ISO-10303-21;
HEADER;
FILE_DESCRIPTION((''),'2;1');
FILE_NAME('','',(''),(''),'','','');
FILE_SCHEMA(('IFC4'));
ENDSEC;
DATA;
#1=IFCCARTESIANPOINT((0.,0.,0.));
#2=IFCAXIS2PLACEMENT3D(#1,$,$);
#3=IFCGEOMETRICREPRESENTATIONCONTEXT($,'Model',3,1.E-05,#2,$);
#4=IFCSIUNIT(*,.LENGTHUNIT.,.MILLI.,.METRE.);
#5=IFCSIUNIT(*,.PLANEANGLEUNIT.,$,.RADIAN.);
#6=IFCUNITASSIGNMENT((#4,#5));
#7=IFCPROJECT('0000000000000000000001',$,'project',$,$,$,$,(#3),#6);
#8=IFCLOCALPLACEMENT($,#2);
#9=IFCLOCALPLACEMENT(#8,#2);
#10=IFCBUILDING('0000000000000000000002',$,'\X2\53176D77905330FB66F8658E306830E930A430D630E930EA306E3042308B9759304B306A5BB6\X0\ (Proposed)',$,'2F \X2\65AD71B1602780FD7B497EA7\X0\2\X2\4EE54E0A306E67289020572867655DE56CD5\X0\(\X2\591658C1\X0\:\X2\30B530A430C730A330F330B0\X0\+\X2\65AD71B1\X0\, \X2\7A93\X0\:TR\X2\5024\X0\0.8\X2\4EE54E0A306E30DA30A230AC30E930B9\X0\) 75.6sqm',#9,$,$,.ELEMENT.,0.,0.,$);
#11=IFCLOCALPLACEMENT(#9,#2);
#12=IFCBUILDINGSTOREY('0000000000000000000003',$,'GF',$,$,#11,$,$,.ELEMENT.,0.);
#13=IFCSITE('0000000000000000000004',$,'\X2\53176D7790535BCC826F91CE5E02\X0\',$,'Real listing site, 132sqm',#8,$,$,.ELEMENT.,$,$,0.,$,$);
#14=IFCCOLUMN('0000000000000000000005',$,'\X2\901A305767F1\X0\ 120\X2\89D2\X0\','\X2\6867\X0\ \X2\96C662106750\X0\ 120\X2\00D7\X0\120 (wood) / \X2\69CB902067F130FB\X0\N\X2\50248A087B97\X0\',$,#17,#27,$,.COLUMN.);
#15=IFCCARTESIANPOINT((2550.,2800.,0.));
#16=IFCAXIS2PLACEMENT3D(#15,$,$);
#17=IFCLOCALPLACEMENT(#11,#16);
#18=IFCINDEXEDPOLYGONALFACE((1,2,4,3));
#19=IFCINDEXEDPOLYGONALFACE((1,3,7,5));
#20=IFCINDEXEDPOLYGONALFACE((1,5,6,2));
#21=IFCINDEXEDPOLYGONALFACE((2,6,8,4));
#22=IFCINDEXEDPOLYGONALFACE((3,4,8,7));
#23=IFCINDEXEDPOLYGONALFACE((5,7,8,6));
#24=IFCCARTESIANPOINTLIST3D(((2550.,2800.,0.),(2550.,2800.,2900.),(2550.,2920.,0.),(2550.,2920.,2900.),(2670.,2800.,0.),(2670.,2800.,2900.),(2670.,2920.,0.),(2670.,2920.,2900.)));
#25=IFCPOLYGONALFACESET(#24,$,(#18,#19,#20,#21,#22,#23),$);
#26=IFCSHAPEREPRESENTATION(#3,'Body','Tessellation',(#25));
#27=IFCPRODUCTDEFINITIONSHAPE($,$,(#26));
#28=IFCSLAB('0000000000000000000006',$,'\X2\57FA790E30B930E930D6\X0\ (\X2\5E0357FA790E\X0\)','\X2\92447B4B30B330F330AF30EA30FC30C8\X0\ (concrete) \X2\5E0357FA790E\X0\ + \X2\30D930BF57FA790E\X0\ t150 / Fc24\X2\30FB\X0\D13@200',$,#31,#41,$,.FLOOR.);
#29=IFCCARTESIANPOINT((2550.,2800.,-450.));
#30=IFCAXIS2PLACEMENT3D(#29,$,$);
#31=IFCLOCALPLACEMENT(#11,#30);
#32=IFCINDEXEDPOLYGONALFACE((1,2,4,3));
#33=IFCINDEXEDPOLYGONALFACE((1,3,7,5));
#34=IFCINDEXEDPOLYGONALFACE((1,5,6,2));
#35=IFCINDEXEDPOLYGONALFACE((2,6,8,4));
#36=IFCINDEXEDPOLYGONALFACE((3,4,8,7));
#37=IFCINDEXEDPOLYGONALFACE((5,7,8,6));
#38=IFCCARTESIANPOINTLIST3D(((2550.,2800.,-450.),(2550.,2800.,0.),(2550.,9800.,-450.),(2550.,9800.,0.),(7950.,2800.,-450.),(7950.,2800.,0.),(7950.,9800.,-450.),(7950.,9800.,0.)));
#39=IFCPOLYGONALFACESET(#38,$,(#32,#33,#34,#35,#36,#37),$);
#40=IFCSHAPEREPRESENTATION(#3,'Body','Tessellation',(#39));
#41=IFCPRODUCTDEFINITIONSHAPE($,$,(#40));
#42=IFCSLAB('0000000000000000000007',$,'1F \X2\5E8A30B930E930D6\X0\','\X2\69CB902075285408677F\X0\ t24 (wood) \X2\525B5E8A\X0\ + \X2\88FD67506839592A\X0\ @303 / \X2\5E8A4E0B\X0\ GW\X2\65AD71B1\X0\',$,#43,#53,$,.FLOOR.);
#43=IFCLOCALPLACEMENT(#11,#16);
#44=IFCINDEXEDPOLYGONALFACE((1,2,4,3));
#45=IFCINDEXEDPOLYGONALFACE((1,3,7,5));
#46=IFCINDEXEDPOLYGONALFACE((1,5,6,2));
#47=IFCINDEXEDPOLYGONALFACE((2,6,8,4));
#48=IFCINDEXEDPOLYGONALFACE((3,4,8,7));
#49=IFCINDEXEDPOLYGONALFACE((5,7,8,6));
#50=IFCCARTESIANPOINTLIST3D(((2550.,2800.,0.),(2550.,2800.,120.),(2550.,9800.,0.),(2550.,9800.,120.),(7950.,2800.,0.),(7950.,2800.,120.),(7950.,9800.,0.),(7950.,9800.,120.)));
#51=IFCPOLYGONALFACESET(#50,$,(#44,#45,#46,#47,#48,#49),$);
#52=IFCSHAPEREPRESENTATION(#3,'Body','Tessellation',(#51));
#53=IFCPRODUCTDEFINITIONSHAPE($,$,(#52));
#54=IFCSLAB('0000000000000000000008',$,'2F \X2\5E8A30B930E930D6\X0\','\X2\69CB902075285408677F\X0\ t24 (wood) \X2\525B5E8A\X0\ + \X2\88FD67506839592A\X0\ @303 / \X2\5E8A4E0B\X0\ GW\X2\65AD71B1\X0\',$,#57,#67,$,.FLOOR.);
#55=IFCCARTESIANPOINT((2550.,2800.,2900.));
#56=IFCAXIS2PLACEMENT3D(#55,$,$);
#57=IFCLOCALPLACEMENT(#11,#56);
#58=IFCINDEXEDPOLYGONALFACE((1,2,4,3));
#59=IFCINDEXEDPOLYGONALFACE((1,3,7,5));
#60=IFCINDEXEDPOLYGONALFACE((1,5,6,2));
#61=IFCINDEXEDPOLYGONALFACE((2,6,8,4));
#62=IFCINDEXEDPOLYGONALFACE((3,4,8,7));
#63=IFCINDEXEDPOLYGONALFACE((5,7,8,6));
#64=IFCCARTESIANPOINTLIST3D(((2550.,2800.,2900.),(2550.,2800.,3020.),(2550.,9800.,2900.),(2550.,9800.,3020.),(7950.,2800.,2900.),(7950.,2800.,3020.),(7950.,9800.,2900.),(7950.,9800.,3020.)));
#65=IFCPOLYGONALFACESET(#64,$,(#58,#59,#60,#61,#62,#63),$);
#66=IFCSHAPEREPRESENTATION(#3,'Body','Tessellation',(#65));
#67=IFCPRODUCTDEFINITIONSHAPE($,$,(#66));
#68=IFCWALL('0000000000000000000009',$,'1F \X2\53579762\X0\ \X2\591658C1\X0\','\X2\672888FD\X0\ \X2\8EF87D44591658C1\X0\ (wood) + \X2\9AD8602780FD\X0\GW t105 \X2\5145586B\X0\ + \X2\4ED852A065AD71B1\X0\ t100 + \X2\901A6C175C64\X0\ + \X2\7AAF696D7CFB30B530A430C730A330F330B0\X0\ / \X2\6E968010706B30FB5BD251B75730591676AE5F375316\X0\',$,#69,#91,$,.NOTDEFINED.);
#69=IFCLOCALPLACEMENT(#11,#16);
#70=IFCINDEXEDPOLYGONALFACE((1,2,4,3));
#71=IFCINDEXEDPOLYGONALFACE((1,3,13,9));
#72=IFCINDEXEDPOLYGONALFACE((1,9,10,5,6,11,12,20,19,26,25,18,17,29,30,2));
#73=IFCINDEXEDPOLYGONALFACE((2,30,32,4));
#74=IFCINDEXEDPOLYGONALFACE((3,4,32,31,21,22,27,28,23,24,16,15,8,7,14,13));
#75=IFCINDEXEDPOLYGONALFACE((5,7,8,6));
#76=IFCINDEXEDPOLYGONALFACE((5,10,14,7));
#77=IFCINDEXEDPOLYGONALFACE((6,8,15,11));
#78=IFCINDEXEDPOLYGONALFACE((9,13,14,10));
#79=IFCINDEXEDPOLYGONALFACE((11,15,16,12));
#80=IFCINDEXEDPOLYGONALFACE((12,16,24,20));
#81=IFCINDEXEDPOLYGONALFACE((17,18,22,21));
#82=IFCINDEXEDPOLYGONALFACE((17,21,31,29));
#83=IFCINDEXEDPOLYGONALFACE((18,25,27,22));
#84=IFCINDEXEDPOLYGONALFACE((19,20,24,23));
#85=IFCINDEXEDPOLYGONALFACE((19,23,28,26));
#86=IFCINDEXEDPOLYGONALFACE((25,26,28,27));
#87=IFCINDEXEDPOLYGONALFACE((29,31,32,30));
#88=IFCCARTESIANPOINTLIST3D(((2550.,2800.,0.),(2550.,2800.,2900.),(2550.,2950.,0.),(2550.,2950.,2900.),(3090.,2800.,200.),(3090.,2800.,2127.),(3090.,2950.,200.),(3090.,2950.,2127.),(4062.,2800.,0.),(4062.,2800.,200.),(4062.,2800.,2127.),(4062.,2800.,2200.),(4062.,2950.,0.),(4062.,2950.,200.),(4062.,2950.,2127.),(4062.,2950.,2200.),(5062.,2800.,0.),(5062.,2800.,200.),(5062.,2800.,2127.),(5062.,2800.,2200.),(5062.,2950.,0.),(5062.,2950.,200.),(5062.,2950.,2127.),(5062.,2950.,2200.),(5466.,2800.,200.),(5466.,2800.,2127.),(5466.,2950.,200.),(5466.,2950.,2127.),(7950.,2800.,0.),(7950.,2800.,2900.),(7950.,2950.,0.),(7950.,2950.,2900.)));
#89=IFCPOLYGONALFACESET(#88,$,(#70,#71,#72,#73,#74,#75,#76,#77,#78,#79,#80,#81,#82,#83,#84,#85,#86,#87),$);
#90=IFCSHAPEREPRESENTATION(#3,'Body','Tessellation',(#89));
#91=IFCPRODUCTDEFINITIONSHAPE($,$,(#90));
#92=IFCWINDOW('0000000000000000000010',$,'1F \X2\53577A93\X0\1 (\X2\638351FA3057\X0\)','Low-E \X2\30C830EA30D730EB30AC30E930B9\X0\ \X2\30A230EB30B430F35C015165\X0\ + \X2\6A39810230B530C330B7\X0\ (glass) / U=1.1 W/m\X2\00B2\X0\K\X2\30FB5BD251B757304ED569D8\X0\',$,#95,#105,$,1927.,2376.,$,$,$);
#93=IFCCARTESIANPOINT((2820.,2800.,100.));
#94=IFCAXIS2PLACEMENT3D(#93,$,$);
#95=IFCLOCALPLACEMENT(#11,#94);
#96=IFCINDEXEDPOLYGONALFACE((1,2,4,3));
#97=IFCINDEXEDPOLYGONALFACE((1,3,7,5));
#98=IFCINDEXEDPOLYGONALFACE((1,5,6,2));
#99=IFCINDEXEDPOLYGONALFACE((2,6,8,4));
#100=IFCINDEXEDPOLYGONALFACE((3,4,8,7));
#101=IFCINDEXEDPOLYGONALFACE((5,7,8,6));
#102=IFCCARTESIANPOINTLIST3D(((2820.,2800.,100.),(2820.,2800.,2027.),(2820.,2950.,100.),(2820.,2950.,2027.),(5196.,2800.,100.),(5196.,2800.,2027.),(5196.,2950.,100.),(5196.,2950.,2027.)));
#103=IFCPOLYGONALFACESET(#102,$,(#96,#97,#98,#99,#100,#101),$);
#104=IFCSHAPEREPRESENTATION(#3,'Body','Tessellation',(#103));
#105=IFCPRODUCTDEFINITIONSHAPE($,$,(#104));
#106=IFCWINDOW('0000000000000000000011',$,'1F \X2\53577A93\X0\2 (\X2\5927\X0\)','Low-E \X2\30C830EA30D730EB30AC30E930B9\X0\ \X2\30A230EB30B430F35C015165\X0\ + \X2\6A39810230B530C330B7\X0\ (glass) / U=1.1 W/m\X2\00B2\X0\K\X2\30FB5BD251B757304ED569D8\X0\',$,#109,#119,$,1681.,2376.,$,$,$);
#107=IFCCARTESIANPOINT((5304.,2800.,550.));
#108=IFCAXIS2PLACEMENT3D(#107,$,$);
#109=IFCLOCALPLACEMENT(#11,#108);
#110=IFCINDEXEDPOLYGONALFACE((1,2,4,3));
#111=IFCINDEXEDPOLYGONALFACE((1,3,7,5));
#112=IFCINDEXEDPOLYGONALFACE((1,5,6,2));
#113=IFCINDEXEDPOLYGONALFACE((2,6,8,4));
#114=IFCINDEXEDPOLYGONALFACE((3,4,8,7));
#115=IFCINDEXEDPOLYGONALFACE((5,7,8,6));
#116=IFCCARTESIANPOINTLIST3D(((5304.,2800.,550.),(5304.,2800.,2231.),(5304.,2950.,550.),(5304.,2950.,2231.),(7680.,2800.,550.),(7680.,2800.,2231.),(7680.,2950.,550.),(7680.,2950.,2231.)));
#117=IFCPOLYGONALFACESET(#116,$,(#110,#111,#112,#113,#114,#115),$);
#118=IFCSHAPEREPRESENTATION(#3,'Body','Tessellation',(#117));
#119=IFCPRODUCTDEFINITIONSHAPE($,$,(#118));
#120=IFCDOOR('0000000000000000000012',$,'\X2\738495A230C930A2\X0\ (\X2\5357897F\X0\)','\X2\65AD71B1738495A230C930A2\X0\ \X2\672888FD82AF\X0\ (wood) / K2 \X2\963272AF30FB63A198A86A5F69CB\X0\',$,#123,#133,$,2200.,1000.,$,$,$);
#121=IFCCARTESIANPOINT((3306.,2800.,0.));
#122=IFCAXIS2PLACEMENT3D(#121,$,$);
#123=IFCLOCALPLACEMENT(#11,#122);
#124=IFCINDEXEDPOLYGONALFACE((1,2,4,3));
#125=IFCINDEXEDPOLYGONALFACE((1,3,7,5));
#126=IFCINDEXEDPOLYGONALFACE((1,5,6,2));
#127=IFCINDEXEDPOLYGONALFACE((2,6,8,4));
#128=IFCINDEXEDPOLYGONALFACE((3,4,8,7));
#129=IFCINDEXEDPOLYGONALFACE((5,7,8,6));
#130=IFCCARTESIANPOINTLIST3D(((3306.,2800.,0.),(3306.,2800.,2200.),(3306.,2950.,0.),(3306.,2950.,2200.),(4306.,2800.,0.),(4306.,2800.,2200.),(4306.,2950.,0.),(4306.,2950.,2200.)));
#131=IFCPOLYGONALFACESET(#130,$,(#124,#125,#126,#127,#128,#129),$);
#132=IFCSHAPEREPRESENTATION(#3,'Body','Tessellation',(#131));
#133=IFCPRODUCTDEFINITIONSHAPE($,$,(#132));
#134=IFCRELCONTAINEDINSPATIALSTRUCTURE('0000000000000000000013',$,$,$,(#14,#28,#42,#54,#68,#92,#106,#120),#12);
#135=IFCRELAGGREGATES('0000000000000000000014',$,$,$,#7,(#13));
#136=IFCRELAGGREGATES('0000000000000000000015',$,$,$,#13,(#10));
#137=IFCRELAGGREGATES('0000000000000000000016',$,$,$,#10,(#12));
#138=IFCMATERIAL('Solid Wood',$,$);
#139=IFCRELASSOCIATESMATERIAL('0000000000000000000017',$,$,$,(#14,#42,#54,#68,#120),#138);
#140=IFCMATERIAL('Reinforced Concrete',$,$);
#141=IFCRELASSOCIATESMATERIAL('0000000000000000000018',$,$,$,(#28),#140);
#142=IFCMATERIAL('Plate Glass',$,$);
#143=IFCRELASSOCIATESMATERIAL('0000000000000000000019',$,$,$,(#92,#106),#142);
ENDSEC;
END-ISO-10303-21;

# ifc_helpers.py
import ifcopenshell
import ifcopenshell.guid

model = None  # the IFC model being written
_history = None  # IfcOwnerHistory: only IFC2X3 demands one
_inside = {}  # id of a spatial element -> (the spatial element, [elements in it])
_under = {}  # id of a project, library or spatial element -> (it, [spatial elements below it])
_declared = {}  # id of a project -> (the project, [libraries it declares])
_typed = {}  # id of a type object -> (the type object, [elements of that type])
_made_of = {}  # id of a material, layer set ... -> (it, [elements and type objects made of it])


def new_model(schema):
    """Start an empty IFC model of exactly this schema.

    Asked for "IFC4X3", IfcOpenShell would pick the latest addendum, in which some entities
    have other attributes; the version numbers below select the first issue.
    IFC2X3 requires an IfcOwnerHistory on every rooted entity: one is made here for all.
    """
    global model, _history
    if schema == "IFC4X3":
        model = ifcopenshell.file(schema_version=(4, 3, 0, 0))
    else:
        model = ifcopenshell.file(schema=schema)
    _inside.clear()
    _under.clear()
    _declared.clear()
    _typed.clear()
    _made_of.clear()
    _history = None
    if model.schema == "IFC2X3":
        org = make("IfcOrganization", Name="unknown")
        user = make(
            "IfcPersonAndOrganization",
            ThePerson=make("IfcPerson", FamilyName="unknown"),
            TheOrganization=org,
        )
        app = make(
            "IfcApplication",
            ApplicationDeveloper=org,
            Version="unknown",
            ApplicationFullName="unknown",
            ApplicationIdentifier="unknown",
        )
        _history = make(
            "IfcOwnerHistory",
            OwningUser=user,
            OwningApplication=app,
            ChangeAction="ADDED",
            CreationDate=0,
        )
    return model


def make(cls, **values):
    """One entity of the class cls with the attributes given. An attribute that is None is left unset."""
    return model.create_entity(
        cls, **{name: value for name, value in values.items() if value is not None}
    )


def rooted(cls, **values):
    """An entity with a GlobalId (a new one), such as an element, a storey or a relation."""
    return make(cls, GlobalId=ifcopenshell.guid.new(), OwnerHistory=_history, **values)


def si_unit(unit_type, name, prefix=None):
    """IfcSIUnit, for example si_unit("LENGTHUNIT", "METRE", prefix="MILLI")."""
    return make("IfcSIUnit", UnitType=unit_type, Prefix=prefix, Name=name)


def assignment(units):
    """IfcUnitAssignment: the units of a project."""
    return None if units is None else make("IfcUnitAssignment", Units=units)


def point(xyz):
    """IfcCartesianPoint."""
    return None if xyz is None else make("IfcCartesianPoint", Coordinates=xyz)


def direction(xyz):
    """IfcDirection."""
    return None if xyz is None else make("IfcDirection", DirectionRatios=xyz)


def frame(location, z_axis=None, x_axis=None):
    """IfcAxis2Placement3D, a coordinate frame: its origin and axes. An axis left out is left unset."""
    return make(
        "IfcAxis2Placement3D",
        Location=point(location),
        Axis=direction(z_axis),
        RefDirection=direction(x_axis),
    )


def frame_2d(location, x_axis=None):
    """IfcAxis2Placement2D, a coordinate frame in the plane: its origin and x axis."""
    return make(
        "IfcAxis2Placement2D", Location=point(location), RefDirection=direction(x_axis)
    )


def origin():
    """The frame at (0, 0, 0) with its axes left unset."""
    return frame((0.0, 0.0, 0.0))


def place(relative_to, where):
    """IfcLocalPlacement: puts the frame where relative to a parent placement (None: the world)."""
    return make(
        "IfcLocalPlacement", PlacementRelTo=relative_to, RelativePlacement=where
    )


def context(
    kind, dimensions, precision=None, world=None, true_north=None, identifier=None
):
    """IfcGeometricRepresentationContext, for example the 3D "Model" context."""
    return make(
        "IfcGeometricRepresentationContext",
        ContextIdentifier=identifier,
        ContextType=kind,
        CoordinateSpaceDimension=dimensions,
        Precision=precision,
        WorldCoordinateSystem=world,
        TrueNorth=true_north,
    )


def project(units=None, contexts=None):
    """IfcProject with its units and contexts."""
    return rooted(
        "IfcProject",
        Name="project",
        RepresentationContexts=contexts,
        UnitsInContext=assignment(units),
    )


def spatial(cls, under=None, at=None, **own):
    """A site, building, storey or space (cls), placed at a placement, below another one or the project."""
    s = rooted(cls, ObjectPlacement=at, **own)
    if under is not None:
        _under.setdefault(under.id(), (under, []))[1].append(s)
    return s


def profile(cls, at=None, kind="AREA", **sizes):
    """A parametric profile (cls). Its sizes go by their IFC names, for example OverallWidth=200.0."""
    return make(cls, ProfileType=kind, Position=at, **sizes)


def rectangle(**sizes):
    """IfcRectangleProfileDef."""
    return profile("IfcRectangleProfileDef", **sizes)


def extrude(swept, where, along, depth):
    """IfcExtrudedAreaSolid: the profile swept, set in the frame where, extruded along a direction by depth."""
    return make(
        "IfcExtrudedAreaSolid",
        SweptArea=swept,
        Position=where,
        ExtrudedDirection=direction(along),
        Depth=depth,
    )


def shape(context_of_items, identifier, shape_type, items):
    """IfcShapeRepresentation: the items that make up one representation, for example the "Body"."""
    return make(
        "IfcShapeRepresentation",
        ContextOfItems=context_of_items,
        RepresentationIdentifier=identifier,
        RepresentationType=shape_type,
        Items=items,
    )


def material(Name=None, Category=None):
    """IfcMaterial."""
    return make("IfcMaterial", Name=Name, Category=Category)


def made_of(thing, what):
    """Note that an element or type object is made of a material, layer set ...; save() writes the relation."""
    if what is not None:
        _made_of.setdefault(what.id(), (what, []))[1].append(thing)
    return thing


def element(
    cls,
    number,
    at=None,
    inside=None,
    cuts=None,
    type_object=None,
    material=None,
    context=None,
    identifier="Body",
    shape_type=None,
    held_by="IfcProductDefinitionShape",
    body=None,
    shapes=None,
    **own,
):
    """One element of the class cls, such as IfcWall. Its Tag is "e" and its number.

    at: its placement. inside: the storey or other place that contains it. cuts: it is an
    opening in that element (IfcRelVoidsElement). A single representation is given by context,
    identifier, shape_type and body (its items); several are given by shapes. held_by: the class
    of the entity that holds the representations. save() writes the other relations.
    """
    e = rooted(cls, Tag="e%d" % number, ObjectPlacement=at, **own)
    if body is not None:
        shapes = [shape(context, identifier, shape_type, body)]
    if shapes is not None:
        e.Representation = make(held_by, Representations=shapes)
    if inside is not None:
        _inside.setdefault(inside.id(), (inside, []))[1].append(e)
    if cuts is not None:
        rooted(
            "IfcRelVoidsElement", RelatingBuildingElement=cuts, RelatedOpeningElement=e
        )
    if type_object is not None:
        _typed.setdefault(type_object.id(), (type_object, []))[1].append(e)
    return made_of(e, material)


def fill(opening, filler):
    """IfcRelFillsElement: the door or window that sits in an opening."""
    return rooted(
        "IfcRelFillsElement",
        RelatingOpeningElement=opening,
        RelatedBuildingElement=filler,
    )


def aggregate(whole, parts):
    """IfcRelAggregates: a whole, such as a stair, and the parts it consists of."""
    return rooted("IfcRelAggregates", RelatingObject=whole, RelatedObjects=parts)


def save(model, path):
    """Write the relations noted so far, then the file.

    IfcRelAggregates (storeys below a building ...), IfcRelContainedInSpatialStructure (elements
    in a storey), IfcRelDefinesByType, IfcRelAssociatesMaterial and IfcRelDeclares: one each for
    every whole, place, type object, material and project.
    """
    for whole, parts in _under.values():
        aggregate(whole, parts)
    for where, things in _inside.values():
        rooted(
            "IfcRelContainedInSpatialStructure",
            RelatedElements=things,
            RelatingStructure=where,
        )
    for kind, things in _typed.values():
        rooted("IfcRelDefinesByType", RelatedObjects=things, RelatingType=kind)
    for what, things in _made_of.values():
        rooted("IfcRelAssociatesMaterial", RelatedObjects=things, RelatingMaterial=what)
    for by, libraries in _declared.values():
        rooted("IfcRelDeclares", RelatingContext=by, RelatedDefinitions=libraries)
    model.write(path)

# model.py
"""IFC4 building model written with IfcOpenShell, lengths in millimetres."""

from ifc_helpers import new_model, si_unit, frame, frame_2d, origin, place, context, project, spatial, rectangle, extrude, material, element, fill, save


model = new_model("IFC4")

# Units and contexts
model_context = context("Model", 3, precision=1e-05, world=origin())
ifc_project = project(units=[si_unit("LENGTHUNIT", "METRE", prefix="MILLI"), si_unit("PLANEANGLEUNIT", "RADIAN")], contexts=[model_context])

# Site, building, storey
site_placement = place(None, origin())
site = spatial("IfcSite", under=ifc_project, at=site_placement, Name="北海道富良野市", ObjectType="Real listing site, 132sqm", CompositionType="ELEMENT", RefElevation=0.0)
building_placement = place(site_placement, origin())
building = spatial("IfcBuilding", under=site, at=building_placement, Name="北海道・書斎とライブラリのある静かな家 (Proposed)", ObjectType="2F 断熱性能等级2以上の木造在来工法(外壁:サイディング+断熱, 窓:TR値0.8以上のペアガラス) 75.6sqm", CompositionType="ELEMENT", ElevationOfRefHeight=0.0, ElevationOfTerrain=0.0)
storey_placement = place(building_placement, origin())
storey = spatial("IfcBuildingStorey", under=building, at=storey_placement, Name="GF", CompositionType="ELEMENT", Elevation=0.0)

# Column
ifc_material_1 = material(Name="Solid Wood")
column_placement = place(storey_placement, frame((2550.0, 2800.0, 0.0)))
element("IfcColumn", 1, at=column_placement, inside=storey, material=ifc_material_1, Name="通し柱 120角", Description="桧 集成材 120×120 (wood) / 構造柱・N値計算", PredefinedType="COLUMN", context=model_context, shape_type="SweptSolid", body=[
    extrude(rectangle(XDim=120.0, YDim=120.0, at=frame_2d((60.0, 60.0))), frame((2550.0, 2800.0, 0.0)), (0.0, 0.0, 1.0), 2900.0),
])

# Slabs
ifc_material_2 = material(Name="Reinforced Concrete")
slab_1_placement = place(storey_placement, frame((2550.0, 2800.0, -450.0)))
element("IfcSlab", 2, at=slab_1_placement, inside=storey, material=ifc_material_2, Name="基礎スラブ (布基礎)", Description="鉄筋コンクリート (concrete) 布基礎 + ベタ基礎 t150 / Fc24・D13@200", PredefinedType="FLOOR", context=model_context, shape_type="SweptSolid", body=[
    extrude(rectangle(XDim=5400.0, YDim=7000.0, at=frame_2d((2700.0, 3500.0))), frame((2550.0, 2800.0, -450.0)), (0.0, 0.0, 1.0), 450.0),
])
slab_2_placement = place(storey_placement, frame((2550.0, 2800.0, 0.0)))
element("IfcSlab", 3, at=slab_2_placement, inside=storey, material=ifc_material_1, Name="1F 床スラブ", Description="構造用合板 t24 (wood) 剛床 + 製材根太 @303 / 床下 GW断熱", PredefinedType="FLOOR", context=model_context, shape_type="SweptSolid", body=[
    extrude(rectangle(XDim=5400.0, YDim=7000.0, at=frame_2d((2700.0, 3500.0))), frame((2550.0, 2800.0, 0.0)), (0.0, 0.0, 1.0), 120.0),
])
slab_3_placement = place(storey_placement, frame((2550.0, 2800.0, 2900.0)))
element("IfcSlab", 4, at=slab_3_placement, inside=storey, material=ifc_material_1, Name="2F 床スラブ", Description="構造用合板 t24 (wood) 剛床 + 製材根太 @303 / 床下 GW断熱", PredefinedType="FLOOR", context=model_context, shape_type="SweptSolid", body=[
    extrude(rectangle(XDim=5400.0, YDim=7000.0, at=frame_2d((2700.0, 3500.0))), frame((2550.0, 2800.0, 2900.0)), (0.0, 0.0, 1.0), 120.0),
])

# Wall, openings, windows, door
wall_1_placement = place(storey_placement, frame((2550.0, 2800.0, 0.0)))
wall_1 = element("IfcWall", 5, at=wall_1_placement, inside=storey, material=ifc_material_1, Name="1F 南面 外壁", Description="木製 軸組外壁 (wood) + 高性能GW t105 充填 + 付加断熱 t100 + 通気層 + 窯業系サイディング / 準耐火・寒冷地外皮強化", PredefinedType="NOTDEFINED", context=model_context, shape_type="SweptSolid", body=[
    extrude(rectangle(XDim=5400.0, YDim=150.0, at=frame_2d((2700.0, 75.0))), frame((2550.0, 2800.0, 0.0)), (0.0, 0.0, 1.0), 2900.0),
])
opening_1_placement = place(storey_placement, frame((2820.0, 2800.0, 100.0)))
opening_1 = element("IfcOpeningElement", 6, at=opening_1_placement, cuts=wall_1, PredefinedType="NOTDEFINED", context=model_context, shape_type="SweptSolid", body=[
    extrude(rectangle(XDim=2376.0, YDim=150.0, at=frame_2d((1188.0, 75.0))), frame((2820.0, 2800.0, 100.0)), (0.0, 0.0, 1.0), 1927.0),
])
opening_2_placement = place(storey_placement, frame((5304.0, 2800.0, 550.0)))
opening_2 = element("IfcOpeningElement", 7, at=opening_2_placement, cuts=wall_1, PredefinedType="NOTDEFINED", context=model_context, shape_type="SweptSolid", body=[
    extrude(rectangle(XDim=2376.0, YDim=150.0, at=frame_2d((1188.0, 75.0))), frame((5304.0, 2800.0, 550.0)), (0.0, 0.0, 1.0), 1681.0),
])
opening_3_placement = place(storey_placement, frame((3306.0, 2800.0, 0.0)))
opening_3 = element("IfcOpeningElement", 8, at=opening_3_placement, cuts=wall_1, PredefinedType="NOTDEFINED", context=model_context, shape_type="SweptSolid", body=[
    extrude(rectangle(XDim=1000.0, YDim=150.0, at=frame_2d((500.0, 75.0))), frame((3306.0, 2800.0, 0.0)), (0.0, 0.0, 1.0), 2200.0),
])
ifc_material_3 = material(Name="Plate Glass")
window_1_placement = place(storey_placement, frame((2820.0, 2800.0, 100.0)))
window_1 = element("IfcWindow", 9, at=window_1_placement, inside=storey, material=ifc_material_3, Name="1F 南窓1 (掃出し)", Description="Low-E トリプルガラス アルゴン封入 + 樹脂サッシ (glass) / U=1.1 W/m²K・寒冷地仕様", OverallHeight=1927.0, OverallWidth=2376.0, context=model_context, shape_type="SweptSolid", body=[
    extrude(rectangle(XDim=2376.0, YDim=150.0, at=frame_2d((1188.0, 75.0))), frame((2820.0, 2800.0, 100.0)), (0.0, 0.0, 1.0), 1927.0),
])
fill(opening_1, window_1)
window_2_placement = place(storey_placement, frame((5304.0, 2800.0, 550.0)))
window_2 = element("IfcWindow", 10, at=window_2_placement, inside=storey, material=ifc_material_3, Name="1F 南窓2 (大)", Description="Low-E トリプルガラス アルゴン封入 + 樹脂サッシ (glass) / U=1.1 W/m²K・寒冷地仕様", OverallHeight=1681.0, OverallWidth=2376.0, context=model_context, shape_type="SweptSolid", body=[
    extrude(rectangle(XDim=2376.0, YDim=150.0, at=frame_2d((1188.0, 75.0))), frame((5304.0, 2800.0, 550.0)), (0.0, 0.0, 1.0), 1681.0),
])
fill(opening_2, window_2)
door_placement = place(storey_placement, frame((3306.0, 2800.0, 0.0)))
door = element("IfcDoor", 11, at=door_placement, inside=storey, material=ifc_material_1, Name="玄関ドア (南西)", Description="断熱玄関ドア 木製芯 (wood) / K2 防犯・採風機構", OverallHeight=2200.0, OverallWidth=1000.0, context=model_context, shape_type="SweptSolid", body=[
    extrude(rectangle(XDim=1000.0, YDim=150.0, at=frame_2d((500.0, 75.0))), frame((3306.0, 2800.0, 0.0)), (0.0, 0.0, 1.0), 2200.0),
])
fill(opening_3, door)

save(model, "model.ifc")
